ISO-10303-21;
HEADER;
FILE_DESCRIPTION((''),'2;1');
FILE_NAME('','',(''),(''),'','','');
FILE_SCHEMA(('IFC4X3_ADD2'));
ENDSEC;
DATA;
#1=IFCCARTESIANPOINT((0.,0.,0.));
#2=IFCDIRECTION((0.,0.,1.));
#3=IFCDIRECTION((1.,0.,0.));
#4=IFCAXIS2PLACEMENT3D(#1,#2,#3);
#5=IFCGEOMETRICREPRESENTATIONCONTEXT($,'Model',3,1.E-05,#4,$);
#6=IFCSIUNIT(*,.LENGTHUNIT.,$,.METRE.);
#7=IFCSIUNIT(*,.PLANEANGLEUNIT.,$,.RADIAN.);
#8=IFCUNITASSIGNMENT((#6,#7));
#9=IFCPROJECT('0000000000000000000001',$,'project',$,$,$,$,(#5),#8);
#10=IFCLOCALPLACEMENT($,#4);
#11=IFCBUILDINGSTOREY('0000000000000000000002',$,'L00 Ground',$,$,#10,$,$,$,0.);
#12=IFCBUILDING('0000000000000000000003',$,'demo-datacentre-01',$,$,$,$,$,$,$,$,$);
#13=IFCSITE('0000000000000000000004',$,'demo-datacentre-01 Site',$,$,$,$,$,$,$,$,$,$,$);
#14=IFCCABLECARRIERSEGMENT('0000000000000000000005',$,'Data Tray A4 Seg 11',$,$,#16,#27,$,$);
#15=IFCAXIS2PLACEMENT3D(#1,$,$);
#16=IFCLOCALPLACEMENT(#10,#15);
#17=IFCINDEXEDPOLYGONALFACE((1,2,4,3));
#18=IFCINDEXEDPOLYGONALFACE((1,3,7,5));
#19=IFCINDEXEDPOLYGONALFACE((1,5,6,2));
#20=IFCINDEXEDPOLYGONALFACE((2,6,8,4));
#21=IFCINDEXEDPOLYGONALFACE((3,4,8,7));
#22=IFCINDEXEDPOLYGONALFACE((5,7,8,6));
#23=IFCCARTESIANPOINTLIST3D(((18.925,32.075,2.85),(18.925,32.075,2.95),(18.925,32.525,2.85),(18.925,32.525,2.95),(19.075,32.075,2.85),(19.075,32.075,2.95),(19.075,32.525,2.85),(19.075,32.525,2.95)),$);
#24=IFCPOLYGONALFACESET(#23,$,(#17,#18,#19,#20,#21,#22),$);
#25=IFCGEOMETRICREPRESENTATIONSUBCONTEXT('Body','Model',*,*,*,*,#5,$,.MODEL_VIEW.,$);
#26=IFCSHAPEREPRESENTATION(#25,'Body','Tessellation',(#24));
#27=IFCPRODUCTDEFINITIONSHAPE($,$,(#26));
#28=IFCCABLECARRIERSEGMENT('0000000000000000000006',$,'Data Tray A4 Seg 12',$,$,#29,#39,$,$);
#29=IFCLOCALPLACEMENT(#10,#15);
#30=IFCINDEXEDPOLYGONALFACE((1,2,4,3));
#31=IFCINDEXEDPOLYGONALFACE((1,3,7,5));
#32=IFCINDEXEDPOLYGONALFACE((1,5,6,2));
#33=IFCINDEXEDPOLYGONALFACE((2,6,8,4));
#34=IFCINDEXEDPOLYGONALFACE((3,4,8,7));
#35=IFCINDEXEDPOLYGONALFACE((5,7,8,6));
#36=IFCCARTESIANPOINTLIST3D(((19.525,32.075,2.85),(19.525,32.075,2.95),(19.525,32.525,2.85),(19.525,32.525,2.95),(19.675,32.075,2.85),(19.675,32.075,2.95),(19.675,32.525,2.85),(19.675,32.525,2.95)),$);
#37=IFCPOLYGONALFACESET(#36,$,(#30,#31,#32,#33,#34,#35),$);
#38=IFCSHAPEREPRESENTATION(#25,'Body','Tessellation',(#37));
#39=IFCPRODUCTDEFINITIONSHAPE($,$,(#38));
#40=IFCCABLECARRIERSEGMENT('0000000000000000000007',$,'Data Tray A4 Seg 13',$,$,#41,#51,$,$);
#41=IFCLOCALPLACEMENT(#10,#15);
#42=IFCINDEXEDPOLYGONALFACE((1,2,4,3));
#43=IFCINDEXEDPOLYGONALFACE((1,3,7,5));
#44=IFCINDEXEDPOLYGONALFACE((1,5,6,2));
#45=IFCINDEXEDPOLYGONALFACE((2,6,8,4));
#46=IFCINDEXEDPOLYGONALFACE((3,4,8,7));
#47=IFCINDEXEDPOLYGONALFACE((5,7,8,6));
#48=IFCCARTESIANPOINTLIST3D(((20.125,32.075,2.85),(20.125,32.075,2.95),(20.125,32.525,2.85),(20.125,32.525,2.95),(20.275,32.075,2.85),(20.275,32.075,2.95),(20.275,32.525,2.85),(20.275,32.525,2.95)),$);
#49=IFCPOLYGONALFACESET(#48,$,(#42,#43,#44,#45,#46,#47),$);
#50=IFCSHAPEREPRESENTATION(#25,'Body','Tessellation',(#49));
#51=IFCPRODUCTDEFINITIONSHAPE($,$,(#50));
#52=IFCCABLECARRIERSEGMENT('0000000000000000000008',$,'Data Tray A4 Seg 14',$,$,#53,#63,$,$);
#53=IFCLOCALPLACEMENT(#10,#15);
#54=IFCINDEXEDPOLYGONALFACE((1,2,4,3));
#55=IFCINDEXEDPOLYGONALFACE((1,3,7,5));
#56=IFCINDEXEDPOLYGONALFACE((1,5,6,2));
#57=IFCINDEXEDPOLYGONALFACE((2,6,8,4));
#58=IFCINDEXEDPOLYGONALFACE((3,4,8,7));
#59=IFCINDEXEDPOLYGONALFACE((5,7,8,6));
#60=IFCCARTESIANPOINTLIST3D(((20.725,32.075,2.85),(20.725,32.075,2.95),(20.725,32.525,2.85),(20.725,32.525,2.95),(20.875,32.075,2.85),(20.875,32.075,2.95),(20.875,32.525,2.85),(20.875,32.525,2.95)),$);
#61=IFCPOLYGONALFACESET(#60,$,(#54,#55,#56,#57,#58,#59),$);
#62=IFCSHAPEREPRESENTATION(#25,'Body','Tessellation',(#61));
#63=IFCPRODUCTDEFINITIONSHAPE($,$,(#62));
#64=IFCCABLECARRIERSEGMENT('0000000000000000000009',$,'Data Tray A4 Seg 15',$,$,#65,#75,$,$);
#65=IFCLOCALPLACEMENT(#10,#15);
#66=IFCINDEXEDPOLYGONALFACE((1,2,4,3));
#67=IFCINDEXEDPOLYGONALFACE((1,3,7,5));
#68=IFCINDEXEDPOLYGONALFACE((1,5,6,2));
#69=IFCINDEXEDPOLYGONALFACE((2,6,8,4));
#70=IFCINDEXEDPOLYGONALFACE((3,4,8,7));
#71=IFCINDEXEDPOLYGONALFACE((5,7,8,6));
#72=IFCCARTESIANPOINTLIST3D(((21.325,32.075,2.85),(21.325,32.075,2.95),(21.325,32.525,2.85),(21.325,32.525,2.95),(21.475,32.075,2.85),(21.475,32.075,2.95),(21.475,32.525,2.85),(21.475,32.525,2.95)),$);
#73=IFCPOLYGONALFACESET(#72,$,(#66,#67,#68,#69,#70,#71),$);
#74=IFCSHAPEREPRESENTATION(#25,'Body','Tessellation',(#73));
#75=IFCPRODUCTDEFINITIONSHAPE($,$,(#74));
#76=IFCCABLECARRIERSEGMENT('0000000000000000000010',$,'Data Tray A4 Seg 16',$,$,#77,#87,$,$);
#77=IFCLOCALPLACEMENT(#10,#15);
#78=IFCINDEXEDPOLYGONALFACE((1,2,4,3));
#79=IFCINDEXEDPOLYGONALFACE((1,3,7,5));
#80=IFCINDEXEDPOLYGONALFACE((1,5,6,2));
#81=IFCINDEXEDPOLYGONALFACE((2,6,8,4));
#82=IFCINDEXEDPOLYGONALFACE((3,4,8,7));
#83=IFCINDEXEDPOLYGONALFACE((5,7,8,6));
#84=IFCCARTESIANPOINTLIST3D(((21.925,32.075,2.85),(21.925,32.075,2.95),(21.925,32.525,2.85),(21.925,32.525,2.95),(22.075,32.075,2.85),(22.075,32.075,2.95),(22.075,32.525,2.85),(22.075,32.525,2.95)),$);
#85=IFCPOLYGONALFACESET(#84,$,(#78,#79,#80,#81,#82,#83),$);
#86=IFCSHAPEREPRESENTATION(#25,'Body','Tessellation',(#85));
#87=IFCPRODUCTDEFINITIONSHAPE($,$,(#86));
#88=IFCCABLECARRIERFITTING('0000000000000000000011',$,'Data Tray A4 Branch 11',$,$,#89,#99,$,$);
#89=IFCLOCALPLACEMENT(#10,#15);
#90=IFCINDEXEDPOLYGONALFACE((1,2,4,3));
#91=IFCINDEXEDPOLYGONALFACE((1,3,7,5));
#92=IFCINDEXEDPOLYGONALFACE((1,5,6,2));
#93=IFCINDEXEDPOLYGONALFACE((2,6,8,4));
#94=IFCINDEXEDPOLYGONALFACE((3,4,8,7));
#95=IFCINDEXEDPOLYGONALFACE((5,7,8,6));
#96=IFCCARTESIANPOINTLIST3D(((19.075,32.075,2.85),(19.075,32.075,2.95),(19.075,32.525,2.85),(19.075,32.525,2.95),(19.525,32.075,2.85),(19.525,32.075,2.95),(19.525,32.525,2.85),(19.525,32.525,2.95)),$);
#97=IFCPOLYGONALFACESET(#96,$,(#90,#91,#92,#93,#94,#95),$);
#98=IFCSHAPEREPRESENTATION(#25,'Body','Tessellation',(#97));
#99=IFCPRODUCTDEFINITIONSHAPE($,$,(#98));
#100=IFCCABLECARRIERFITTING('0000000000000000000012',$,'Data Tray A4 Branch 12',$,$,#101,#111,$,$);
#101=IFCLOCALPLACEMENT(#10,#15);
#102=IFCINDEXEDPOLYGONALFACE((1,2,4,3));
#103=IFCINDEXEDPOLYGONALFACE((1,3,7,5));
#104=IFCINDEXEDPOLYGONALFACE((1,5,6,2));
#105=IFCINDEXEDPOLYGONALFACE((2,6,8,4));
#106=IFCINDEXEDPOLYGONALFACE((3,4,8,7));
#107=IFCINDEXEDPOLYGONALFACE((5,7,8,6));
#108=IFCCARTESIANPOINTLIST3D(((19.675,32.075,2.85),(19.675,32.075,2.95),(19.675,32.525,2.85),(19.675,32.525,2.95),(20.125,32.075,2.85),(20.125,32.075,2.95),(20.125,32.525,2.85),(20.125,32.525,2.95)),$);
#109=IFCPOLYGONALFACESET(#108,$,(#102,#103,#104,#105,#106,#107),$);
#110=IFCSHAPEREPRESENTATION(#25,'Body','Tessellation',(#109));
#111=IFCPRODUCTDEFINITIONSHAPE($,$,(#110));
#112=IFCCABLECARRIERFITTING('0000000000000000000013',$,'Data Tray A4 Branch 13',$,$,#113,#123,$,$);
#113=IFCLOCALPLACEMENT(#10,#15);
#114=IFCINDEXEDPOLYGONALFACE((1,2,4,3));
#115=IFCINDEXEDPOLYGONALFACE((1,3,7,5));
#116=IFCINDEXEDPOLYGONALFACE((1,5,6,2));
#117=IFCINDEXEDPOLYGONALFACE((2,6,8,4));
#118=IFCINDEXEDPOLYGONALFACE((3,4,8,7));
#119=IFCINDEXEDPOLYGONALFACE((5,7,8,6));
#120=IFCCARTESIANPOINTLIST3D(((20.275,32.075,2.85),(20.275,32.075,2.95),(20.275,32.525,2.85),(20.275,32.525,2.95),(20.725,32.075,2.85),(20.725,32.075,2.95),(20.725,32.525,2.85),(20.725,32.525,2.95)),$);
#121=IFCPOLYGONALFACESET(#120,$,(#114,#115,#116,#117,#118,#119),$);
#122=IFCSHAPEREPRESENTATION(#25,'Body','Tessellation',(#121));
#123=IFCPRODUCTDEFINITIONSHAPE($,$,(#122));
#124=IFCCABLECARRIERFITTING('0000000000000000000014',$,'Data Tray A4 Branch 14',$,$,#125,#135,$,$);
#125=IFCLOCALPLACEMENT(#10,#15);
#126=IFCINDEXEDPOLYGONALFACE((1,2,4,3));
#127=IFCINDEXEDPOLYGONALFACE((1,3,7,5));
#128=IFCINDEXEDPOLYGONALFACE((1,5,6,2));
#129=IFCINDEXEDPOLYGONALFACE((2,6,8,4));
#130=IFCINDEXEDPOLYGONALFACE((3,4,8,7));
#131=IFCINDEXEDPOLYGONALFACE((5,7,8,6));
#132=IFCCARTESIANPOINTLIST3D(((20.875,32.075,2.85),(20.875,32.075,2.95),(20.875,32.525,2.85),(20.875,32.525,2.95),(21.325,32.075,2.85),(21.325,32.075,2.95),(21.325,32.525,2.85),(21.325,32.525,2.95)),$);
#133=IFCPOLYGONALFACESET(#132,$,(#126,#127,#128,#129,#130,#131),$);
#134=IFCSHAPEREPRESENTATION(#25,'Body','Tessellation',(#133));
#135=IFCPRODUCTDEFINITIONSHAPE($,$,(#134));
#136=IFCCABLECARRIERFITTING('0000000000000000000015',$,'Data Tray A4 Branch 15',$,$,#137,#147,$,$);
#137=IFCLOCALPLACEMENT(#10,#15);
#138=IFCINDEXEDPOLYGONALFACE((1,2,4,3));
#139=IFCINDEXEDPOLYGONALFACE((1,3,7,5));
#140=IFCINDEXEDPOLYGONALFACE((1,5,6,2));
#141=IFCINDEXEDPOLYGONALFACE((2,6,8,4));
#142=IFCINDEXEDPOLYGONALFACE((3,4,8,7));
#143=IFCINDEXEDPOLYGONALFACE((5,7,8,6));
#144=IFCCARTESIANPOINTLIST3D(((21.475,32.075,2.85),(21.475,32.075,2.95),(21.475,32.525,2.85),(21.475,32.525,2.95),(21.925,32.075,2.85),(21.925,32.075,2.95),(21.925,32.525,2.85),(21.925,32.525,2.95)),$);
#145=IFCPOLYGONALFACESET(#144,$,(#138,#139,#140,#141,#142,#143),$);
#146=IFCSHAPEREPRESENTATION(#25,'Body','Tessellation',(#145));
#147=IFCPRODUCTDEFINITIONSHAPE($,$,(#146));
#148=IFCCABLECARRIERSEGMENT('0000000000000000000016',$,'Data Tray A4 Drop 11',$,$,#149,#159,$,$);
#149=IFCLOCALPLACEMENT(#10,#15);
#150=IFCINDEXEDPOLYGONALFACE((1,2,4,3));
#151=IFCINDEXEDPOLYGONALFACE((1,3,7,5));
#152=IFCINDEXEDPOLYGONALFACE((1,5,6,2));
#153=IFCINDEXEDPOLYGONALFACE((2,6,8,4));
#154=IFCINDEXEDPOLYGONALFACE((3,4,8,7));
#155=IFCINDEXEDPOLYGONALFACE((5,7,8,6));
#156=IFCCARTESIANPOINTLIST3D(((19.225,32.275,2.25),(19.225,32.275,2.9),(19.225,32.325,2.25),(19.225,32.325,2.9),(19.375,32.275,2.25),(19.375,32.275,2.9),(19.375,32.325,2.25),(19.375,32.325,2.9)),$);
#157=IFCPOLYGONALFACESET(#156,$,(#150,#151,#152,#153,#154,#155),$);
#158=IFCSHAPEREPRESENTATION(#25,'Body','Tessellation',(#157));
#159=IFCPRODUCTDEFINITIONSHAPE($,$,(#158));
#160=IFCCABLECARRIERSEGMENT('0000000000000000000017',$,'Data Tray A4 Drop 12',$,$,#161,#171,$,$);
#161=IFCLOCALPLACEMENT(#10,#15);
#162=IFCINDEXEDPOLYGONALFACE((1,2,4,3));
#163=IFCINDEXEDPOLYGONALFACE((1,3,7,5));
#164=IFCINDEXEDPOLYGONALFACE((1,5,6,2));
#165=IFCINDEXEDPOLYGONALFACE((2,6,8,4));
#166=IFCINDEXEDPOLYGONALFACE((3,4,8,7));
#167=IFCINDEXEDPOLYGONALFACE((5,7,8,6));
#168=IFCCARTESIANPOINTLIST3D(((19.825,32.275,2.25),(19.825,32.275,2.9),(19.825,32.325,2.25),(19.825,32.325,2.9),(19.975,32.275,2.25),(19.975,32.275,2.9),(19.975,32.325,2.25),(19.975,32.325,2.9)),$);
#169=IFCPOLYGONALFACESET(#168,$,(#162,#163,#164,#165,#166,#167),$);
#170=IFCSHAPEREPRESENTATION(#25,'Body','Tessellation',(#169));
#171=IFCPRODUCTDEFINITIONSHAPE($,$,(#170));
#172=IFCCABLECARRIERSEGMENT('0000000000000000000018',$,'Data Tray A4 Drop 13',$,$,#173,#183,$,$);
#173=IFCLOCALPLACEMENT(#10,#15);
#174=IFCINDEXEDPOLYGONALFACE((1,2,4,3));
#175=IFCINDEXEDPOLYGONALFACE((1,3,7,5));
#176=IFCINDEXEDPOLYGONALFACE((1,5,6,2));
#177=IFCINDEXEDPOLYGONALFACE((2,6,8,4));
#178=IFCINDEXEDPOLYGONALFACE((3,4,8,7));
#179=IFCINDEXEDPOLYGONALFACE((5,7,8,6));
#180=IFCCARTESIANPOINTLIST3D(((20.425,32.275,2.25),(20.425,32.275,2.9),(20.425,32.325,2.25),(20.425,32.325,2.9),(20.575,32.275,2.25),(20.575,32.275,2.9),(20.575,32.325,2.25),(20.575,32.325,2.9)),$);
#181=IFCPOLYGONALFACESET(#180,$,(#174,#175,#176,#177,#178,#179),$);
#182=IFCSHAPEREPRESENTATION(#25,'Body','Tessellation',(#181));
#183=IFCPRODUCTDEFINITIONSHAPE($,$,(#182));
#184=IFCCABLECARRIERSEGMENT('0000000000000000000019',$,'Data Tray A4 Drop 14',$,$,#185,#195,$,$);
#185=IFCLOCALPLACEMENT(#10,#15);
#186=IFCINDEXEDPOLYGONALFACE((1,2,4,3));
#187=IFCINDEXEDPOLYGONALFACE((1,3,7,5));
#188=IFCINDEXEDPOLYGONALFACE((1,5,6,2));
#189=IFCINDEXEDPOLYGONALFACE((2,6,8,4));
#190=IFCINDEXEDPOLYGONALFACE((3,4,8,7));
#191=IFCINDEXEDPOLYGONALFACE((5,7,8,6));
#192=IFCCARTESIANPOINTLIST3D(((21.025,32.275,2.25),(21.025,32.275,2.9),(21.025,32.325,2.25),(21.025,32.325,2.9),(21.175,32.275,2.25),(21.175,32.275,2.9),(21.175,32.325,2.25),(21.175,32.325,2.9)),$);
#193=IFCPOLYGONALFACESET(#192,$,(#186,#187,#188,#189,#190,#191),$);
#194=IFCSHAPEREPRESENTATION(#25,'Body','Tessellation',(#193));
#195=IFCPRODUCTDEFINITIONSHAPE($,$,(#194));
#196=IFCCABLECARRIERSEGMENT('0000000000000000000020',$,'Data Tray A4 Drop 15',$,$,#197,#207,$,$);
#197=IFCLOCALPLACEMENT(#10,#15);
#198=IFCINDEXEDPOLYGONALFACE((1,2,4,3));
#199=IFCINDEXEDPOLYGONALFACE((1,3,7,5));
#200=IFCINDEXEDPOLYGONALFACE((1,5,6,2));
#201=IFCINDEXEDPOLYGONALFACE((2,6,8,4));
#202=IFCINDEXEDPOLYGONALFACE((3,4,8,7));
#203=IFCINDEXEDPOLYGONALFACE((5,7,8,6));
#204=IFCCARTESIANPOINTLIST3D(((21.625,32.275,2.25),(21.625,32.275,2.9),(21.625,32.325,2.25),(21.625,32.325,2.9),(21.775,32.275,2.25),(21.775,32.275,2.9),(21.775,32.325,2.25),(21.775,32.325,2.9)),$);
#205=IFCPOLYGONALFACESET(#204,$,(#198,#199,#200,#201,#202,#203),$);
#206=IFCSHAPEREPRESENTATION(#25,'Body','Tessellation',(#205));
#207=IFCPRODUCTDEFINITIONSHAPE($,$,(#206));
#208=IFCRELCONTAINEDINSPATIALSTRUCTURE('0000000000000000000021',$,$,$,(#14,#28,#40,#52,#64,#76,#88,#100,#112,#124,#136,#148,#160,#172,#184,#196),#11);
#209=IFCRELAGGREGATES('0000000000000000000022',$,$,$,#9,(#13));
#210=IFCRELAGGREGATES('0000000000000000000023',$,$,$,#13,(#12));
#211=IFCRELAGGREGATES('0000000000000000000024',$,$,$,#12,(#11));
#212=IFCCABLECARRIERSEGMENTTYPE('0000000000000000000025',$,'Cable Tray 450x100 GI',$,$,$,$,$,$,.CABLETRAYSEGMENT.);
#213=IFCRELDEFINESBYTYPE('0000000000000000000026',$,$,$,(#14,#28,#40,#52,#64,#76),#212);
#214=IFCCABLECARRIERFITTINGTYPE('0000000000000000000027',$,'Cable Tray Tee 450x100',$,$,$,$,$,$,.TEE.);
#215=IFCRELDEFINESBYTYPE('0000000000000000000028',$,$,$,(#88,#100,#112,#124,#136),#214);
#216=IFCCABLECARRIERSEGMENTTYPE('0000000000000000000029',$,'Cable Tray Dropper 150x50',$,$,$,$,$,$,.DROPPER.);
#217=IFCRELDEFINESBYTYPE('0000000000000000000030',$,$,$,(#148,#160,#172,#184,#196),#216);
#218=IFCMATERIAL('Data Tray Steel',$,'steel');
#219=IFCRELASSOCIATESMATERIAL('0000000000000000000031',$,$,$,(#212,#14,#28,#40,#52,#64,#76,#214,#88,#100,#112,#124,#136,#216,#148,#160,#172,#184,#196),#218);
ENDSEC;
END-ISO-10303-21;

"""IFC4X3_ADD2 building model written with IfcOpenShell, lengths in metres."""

from ifc_helpers import new_model, si_unit, frame, origin_with_axes, place, context, subcontext, project, spatial, rectangle, extrude, material, type_object, element, save


model = new_model("IFC4X3_ADD2")

# Units and contexts
model_context = context("Model", 3, precision=1e-05, world=origin_with_axes())
body_context = subcontext(model_context, "Body", "Model", "MODEL_VIEW")
ifc_project = project(units=[si_unit("LENGTHUNIT", "METRE"), si_unit("PLANEANGLEUNIT", "RADIAN")], contexts=[model_context])

# Site, building, storey
site = spatial("IfcSite", under=ifc_project, Name="demo-datacentre-01 Site")
building = spatial("IfcBuilding", under=site, Name="demo-datacentre-01")
storey_placement = place(None, origin_with_axes())
storey = spatial("IfcBuildingStorey", under=building, at=storey_placement, Name="L00 Ground", Elevation=0.0)

# Cable carrier segments
ifc_material_1 = material(Name="Data Tray Steel", Category="steel")
cable_carrier_segment_type_1 = type_object("IfcCableCarrierSegmentType", Name="Cable Tray 450x100 GI", PredefinedType="CABLETRAYSEGMENT", material=ifc_material_1)
cable_carrier_segment_1_placement = place(storey_placement, frame((18.925, 32.3, 2.9), z_axis=(1.0, 0.0, 0.0), x_axis=(0.0, 1.0, 0.0)))
element("IfcCableCarrierSegment", 1, at=cable_carrier_segment_1_placement, inside=storey, type_object=cable_carrier_segment_type_1, material=ifc_material_1, Name="Data Tray A4 Seg 11", context=body_context, shape_type="SweptSolid", body=[
    extrude(rectangle(XDim=0.45, YDim=0.1), origin_with_axes(), (0.0, 0.0, 1.0), 0.15),
])
cable_carrier_segment_2_placement = place(storey_placement, frame((19.525, 32.3, 2.9), z_axis=(1.0, 0.0, 0.0), x_axis=(0.0, 1.0, 0.0)))
element("IfcCableCarrierSegment", 2, at=cable_carrier_segment_2_placement, inside=storey, type_object=cable_carrier_segment_type_1, material=ifc_material_1, Name="Data Tray A4 Seg 12", context=body_context, shape_type="SweptSolid", body=[
    extrude(rectangle(XDim=0.45, YDim=0.1), origin_with_axes(), (0.0, 0.0, 1.0), 0.15),
])
for number, where, z_axis, x_axis, name in (
    (3, (20.125, 32.3, 2.9), (1.0, 0.0, 0.0), (0.0, 1.0, 0.0), "Data Tray A4 Seg 13"),
    (4, (20.725, 32.3, 2.9), (1.0, 0.0, 0.0), (0.0, 1.0, 0.0), "Data Tray A4 Seg 14"),
    (5, (21.325, 32.3, 2.9), (1.0, 0.0, 0.0), (0.0, 1.0, 0.0), "Data Tray A4 Seg 15"),
):
    element("IfcCableCarrierSegment", number, at=place(storey_placement, frame(where, z_axis=z_axis, x_axis=x_axis)), inside=storey, type_object=cable_carrier_segment_type_1, material=ifc_material_1, Name=name, context=body_context, shape_type="SweptSolid", body=[
        extrude(rectangle(XDim=0.45, YDim=0.1), origin_with_axes(), (0.0, 0.0, 1.0), 0.15),
    ])
cable_carrier_segment_3_placement = place(storey_placement, frame((21.925, 32.3, 2.9), z_axis=(1.0, 0.0, 0.0), x_axis=(0.0, 1.0, 0.0)))
element("IfcCableCarrierSegment", 6, at=cable_carrier_segment_3_placement, inside=storey, type_object=cable_carrier_segment_type_1, material=ifc_material_1, Name="Data Tray A4 Seg 16", context=body_context, shape_type="SweptSolid", body=[
    extrude(rectangle(XDim=0.45, YDim=0.1), origin_with_axes(), (0.0, 0.0, 1.0), 0.15),
])

# Cable carrier fittings
cable_carrier_fitting_type = type_object("IfcCableCarrierFittingType", Name="Cable Tray Tee 450x100", PredefinedType="TEE", material=ifc_material_1)
for number, where, z_axis, x_axis, name in (
    (7, (19.3, 32.3, 2.85), (0.0, 0.0, 1.0), (1.0, 0.0, 0.0), "Data Tray A4 Branch 11"),
    (8, (19.9, 32.3, 2.85), (0.0, 0.0, 1.0), (1.0, 0.0, 0.0), "Data Tray A4 Branch 12"),
    (9, (20.5, 32.3, 2.85), (0.0, 0.0, 1.0), (1.0, 0.0, 0.0), "Data Tray A4 Branch 13"),
    (10, (21.1, 32.3, 2.85), (0.0, 0.0, 1.0), (1.0, 0.0, 0.0), "Data Tray A4 Branch 14"),
    (11, (21.7, 32.3, 2.85), (0.0, 0.0, 1.0), (1.0, 0.0, 0.0), "Data Tray A4 Branch 15"),
):
    element("IfcCableCarrierFitting", number, at=place(storey_placement, frame(where, z_axis=z_axis, x_axis=x_axis)), inside=storey, type_object=cable_carrier_fitting_type, material=ifc_material_1, Name=name, context=body_context, shape_type="SweptSolid", body=[
        extrude(rectangle(XDim=0.45, YDim=0.45), origin_with_axes(), (0.0, 0.0, 1.0), 0.1),
    ])

# Cable carrier segments
cable_carrier_segment_type_2 = type_object("IfcCableCarrierSegmentType", Name="Cable Tray Dropper 150x50", PredefinedType="DROPPER", material=ifc_material_1)
for number, where, z_axis, x_axis, name in (
    (12, (19.3, 32.3, 2.9), (0.0, 0.0, -1.0), (1.0, 0.0, 0.0), "Data Tray A4 Drop 11"),
    (13, (19.9, 32.3, 2.9), (0.0, 0.0, -1.0), (1.0, 0.0, 0.0), "Data Tray A4 Drop 12"),
    (14, (20.5, 32.3, 2.9), (0.0, 0.0, -1.0), (1.0, 0.0, 0.0), "Data Tray A4 Drop 13"),
    (15, (21.1, 32.3, 2.9), (0.0, 0.0, -1.0), (1.0, 0.0, 0.0), "Data Tray A4 Drop 14"),
    (16, (21.7, 32.3, 2.9), (0.0, 0.0, -1.0), (1.0, 0.0, 0.0), "Data Tray A4 Drop 15"),
):
    element("IfcCableCarrierSegment", number, at=place(storey_placement, frame(where, z_axis=z_axis, x_axis=x_axis)), inside=storey, type_object=cable_carrier_segment_type_2, material=ifc_material_1, Name=name, context=body_context, shape_type="SweptSolid", body=[
        extrude(rectangle(XDim=0.15, YDim=0.05), origin_with_axes(), (0.0, 0.0, 1.0), 0.65),
    ])

save(model, "model.ifc")
